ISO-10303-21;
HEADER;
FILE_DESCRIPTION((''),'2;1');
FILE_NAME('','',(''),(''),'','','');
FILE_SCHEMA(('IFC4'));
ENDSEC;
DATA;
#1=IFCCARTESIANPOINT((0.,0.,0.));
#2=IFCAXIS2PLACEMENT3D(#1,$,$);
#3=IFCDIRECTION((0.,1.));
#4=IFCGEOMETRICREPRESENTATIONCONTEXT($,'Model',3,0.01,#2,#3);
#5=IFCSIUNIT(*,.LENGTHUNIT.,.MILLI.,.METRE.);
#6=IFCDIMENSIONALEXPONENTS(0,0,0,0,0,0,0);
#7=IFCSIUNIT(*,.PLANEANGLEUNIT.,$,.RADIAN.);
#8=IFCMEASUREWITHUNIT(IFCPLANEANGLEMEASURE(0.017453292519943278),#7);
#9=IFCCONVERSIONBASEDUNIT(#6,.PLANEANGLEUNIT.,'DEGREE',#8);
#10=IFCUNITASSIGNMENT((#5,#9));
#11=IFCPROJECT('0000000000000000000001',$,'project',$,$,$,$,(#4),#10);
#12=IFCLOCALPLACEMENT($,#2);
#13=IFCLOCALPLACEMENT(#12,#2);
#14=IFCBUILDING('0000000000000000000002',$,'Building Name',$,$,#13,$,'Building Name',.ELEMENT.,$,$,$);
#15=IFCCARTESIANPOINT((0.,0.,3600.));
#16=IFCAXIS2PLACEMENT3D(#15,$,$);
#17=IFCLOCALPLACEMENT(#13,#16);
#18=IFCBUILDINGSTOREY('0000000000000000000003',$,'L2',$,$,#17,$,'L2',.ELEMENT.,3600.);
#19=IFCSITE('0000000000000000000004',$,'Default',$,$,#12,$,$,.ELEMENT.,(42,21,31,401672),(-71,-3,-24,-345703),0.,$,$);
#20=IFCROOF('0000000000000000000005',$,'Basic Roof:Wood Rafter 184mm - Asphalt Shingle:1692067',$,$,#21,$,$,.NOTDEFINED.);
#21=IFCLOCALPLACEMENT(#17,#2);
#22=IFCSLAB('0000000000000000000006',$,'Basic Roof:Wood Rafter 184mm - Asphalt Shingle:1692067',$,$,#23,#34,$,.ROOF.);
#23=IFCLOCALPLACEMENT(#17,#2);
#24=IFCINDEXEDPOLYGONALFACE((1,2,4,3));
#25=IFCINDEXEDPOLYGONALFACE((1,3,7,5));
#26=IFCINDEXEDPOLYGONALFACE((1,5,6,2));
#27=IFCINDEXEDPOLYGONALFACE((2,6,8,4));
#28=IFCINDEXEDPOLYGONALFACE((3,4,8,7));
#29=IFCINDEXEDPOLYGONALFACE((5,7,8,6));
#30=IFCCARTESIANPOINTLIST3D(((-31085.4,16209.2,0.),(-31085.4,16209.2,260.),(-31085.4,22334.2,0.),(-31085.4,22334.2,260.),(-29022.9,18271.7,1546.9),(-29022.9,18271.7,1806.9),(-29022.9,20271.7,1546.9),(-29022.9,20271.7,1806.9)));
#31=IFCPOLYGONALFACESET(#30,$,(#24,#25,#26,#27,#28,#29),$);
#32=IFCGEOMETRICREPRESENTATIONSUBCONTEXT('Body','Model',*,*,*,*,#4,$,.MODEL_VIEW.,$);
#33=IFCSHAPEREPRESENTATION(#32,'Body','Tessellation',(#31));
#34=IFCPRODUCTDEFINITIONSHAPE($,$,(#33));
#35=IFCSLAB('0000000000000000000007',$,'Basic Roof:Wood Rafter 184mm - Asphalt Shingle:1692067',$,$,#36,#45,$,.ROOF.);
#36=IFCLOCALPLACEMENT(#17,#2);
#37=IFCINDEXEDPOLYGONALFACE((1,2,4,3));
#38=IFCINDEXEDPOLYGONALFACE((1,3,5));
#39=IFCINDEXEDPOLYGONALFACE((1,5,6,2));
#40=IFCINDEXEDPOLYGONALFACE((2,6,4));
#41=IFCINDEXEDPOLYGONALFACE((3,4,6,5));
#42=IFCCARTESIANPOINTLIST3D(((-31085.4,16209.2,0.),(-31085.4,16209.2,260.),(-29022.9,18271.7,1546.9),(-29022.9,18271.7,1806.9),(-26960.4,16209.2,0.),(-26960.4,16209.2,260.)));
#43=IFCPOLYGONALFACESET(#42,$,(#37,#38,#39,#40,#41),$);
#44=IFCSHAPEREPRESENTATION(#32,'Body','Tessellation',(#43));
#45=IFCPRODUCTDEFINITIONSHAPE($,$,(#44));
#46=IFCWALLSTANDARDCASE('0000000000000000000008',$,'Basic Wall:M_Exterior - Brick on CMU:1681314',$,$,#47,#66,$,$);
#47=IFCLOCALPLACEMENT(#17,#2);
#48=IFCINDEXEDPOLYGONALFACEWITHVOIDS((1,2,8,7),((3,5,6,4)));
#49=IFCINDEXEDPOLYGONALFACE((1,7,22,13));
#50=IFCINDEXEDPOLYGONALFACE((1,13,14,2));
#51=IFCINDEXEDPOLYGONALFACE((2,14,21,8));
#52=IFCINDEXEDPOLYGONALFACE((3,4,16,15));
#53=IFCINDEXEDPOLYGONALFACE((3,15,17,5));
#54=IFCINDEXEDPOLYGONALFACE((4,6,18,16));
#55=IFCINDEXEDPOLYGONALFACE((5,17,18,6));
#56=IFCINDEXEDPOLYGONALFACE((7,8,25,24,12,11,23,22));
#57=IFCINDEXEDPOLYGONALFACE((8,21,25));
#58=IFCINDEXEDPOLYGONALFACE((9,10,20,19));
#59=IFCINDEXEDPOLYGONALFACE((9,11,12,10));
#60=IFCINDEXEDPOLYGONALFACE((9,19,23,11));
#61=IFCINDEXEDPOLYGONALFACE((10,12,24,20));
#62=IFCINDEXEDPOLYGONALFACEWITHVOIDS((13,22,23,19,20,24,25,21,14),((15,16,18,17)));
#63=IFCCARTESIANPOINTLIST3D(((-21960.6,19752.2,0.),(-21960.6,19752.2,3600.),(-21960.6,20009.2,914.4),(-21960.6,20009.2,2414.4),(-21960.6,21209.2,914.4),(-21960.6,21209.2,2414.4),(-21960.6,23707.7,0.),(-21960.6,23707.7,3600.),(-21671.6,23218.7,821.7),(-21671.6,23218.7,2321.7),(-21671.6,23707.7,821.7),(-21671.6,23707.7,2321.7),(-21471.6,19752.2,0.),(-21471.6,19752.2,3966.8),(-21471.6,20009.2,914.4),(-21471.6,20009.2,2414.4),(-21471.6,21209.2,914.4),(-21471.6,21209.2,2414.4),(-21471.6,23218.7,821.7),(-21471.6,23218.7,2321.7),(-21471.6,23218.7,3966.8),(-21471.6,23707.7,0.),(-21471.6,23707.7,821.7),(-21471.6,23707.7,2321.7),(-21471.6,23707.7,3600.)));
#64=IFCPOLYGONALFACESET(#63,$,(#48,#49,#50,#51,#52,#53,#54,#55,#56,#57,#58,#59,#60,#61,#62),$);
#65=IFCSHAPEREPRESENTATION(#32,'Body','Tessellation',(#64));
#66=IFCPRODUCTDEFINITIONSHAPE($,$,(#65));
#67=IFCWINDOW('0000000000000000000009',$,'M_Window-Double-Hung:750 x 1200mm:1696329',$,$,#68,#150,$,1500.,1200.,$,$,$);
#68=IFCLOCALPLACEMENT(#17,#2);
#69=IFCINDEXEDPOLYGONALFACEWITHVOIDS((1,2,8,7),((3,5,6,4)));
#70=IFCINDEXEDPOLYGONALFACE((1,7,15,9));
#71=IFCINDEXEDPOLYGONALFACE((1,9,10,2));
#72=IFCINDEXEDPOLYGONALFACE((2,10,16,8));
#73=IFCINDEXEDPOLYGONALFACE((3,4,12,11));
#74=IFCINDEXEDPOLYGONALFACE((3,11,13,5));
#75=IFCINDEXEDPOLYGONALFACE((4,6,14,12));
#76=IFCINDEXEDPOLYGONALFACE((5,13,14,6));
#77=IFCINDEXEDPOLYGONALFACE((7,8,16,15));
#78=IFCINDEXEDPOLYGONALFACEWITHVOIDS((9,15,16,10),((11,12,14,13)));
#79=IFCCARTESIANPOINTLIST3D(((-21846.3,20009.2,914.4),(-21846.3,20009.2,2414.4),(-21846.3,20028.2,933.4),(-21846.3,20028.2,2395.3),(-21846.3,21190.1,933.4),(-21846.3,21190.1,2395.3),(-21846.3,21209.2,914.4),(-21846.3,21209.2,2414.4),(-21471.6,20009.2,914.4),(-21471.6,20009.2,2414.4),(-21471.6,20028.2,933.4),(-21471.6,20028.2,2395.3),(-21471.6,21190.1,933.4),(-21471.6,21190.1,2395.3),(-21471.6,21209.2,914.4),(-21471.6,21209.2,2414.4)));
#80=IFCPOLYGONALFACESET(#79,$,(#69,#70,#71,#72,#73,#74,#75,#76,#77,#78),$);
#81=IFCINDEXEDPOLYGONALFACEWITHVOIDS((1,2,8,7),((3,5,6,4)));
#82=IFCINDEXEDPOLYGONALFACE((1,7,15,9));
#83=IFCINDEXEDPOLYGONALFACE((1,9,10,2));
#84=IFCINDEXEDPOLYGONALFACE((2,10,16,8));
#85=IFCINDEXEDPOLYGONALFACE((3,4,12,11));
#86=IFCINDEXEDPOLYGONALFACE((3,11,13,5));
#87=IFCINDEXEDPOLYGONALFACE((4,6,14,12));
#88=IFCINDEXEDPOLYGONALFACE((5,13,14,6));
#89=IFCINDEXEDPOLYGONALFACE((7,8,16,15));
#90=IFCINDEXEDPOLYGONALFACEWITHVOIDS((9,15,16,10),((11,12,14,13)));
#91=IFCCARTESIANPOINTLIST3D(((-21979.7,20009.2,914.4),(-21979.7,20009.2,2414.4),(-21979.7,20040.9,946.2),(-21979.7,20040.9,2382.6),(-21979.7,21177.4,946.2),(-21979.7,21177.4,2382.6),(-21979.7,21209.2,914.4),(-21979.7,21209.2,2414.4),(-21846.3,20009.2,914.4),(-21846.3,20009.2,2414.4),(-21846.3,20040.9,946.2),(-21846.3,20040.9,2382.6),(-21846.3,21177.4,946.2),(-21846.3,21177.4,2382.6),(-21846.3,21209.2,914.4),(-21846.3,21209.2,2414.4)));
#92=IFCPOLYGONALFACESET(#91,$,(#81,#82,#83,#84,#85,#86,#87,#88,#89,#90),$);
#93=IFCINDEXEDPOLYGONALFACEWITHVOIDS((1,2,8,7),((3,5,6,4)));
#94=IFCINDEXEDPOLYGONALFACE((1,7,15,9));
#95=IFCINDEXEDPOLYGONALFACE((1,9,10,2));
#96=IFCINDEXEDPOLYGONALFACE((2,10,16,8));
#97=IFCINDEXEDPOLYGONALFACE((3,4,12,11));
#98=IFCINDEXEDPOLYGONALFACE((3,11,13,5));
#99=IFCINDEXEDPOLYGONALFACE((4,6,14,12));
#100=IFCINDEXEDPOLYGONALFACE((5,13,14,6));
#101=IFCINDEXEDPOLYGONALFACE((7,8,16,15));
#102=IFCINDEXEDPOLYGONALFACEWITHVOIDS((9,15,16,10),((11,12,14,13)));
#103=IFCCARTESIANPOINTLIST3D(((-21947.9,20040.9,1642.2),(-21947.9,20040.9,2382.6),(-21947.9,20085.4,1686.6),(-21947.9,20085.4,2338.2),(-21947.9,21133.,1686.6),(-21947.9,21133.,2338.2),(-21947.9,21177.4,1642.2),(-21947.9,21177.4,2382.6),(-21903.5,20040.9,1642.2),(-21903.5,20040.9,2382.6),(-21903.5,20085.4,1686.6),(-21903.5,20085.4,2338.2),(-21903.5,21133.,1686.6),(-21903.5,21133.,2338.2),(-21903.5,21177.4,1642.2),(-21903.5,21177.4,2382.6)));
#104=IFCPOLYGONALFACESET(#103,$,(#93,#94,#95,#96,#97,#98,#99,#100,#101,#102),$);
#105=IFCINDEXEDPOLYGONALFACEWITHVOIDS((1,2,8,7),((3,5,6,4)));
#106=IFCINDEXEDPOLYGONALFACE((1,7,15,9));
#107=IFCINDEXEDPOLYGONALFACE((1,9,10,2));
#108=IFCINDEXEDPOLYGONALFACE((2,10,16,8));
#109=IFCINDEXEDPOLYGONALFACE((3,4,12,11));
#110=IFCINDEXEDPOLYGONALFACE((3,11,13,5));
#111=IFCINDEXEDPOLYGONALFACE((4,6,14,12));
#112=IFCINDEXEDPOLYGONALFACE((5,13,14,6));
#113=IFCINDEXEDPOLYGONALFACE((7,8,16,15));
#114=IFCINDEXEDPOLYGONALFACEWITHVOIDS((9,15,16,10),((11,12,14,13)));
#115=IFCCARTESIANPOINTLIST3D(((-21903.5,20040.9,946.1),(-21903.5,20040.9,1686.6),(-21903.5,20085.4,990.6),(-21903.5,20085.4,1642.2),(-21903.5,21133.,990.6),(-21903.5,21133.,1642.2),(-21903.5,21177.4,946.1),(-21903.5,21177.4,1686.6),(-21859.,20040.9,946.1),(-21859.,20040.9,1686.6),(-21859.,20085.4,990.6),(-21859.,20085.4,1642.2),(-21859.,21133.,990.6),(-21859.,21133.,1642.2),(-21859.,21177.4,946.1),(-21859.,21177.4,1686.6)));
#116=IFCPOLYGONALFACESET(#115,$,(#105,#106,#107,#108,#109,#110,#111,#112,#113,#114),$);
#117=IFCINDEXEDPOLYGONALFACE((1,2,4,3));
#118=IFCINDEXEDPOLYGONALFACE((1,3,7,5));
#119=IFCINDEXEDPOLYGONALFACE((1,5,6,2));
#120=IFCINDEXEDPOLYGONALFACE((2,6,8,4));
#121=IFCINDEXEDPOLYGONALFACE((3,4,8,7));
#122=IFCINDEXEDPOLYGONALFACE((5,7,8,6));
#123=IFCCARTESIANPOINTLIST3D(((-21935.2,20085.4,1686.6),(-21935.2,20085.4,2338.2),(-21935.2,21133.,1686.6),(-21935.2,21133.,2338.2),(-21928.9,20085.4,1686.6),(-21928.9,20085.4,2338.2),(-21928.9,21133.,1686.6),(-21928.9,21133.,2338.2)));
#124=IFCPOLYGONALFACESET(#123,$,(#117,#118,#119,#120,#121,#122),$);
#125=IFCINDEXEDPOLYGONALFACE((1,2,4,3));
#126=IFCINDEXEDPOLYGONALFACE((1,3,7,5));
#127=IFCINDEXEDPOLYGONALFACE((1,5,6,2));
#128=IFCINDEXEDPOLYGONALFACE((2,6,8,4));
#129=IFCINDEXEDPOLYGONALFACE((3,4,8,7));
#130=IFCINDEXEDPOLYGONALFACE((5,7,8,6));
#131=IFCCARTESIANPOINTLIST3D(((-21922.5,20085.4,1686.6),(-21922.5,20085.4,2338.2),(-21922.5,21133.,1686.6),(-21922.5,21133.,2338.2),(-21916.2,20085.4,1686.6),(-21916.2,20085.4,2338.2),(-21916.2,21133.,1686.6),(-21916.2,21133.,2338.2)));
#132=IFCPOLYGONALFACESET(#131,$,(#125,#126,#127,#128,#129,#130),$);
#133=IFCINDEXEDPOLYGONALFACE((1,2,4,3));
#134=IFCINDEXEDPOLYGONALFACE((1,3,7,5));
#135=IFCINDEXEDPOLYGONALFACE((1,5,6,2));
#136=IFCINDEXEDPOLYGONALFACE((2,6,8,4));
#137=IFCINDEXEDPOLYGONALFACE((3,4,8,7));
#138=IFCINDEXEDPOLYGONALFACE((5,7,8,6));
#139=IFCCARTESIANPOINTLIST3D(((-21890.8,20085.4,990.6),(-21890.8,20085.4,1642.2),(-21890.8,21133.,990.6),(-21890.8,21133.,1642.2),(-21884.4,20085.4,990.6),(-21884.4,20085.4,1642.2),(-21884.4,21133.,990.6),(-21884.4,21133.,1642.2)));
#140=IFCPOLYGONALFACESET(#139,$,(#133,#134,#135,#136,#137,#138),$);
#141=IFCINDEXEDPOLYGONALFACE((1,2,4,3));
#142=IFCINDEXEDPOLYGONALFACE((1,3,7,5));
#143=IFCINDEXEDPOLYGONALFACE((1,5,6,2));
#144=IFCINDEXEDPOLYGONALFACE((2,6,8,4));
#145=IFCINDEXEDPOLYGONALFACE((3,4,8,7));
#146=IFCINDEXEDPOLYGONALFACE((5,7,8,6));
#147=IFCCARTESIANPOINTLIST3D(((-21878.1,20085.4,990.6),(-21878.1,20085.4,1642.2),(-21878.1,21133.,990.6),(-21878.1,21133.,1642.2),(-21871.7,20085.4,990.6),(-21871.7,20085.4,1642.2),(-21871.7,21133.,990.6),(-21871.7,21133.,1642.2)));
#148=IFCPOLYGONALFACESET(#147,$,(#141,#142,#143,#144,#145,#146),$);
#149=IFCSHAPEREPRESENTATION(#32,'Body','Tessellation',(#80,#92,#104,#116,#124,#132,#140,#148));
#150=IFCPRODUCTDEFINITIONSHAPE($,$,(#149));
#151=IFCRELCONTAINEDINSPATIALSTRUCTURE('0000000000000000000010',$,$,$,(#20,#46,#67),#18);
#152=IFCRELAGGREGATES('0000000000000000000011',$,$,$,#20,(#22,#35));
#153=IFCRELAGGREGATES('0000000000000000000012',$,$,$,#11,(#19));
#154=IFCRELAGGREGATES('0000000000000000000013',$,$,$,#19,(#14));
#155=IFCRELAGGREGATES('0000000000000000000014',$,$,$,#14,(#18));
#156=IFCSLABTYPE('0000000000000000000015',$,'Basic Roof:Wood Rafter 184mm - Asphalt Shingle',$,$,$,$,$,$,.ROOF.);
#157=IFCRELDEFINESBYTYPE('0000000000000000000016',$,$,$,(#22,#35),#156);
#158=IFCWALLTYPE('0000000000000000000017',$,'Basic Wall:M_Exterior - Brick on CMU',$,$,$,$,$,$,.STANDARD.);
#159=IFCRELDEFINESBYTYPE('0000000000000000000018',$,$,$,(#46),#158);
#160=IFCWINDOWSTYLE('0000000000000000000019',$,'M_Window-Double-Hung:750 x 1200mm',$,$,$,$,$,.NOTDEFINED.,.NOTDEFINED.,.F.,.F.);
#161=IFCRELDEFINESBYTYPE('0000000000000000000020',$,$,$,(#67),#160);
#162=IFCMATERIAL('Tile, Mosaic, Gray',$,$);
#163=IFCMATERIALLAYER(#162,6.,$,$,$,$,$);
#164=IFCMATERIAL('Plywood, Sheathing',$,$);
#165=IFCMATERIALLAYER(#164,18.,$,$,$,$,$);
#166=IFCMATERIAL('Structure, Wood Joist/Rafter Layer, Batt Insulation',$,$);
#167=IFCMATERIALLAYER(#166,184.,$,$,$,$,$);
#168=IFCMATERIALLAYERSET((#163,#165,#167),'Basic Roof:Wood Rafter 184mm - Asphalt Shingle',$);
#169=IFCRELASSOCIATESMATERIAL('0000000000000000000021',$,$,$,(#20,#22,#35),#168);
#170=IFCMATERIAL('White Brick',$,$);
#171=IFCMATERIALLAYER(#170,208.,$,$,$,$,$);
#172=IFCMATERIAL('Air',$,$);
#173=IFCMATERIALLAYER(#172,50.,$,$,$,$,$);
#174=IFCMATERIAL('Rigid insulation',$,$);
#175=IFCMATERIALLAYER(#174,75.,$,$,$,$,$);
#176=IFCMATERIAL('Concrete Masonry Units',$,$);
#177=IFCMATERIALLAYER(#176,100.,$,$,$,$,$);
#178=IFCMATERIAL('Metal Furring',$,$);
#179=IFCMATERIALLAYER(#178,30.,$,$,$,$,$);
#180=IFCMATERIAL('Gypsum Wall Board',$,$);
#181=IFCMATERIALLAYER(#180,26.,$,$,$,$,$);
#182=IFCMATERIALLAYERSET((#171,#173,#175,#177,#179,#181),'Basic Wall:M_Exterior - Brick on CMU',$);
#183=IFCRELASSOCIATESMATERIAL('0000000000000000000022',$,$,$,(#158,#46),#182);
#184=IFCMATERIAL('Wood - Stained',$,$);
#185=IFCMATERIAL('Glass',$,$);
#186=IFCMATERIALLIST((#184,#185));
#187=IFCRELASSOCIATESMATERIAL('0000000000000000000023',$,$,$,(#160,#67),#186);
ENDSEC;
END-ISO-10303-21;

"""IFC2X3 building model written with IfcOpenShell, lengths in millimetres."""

from ifc_helpers import new_model, entity, si_unit, converted_unit, direction, frame, frame_2d, origin, place, context, subcontext, project, spatial, polyline, rectangle, outline, extrude, clip, bounded_halfspace, source, transform, mapped, material, material_list, layer, layer_set, layer_usage, type_object, type_shapes, element, fill, aggregate, save


model = new_model("IFC2X3")

# Units and contexts
model_context = context("Model", 3, precision=0.01, world=origin(), true_north=direction((0.0, 1.0)))
body_context = subcontext(model_context, "Body", "Model", "MODEL_VIEW")
ifc_project = project(units=[si_unit("LENGTHUNIT", "METRE", prefix="MILLI"), converted_unit("PLANEANGLEUNIT", "DEGREE", entity("IfcPlaneAngleMeasure", 0.017453292519943278), si_unit("PLANEANGLEUNIT", "RADIAN"), dimensions=[0, 0, 0, 0, 0, 0, 0])], contexts=[model_context])

# Site, building, storey
site_placement = place(None, origin())
site = spatial("IfcSite", under=ifc_project, at=site_placement, Name="Default", CompositionType="ELEMENT", RefLatitude=(42, 21, 31, 401672), RefLongitude=(-71, -3, -24, -345703), RefElevation=0.0)
building_placement = place(site_placement, origin())
building = spatial("IfcBuilding", under=site, at=building_placement, Name="Building Name", LongName="Building Name", CompositionType="ELEMENT")
storey_placement = place(building_placement, frame((0.0, 0.0, 3600.0)))
storey = spatial("IfcBuildingStorey", under=building, at=storey_placement, Name="L2", LongName="L2", CompositionType="ELEMENT", Elevation=3600.0)

# Roof, slabs
ifc_material_1 = material(Name="Tile, Mosaic, Gray")
ifc_layer_1 = layer(ifc_material_1, 6.0)
ifc_material_2 = material(Name="Plywood, Sheathing")
ifc_layer_2 = layer(ifc_material_2, 18.0)
ifc_material_3 = material(Name="Structure, Wood Joist/Rafter Layer, Batt Insulation")
ifc_layer_3 = layer(ifc_material_3, 184.0)
ifc_layer_set_1 = layer_set([ifc_layer_1, ifc_layer_2, ifc_layer_3], Name="Basic Roof:Wood Rafter 184mm - Asphalt Shingle")
slab_type = type_object("IfcSlabType", Name="Basic Roof:Wood Rafter 184mm - Asphalt Shingle", PredefinedType="ROOF")
roof_1_placement = place(storey_placement, frame((-31085.4, 16209.2, 0.0)))
roof_1 = element("IfcRoof", 1, at=roof_1_placement, inside=storey, material=ifc_layer_set_1, Name="Basic Roof:Wood Rafter 184mm - Asphalt Shingle:1692067", ShapeType="NOTDEFINED")
slab_1_placement = place(roof_1_placement, origin())
slab_1 = element("IfcSlab", 2, at=slab_1_placement, type_object=slab_type, material=ifc_layer_set_1, Name="Basic Roof:Wood Rafter 184mm - Asphalt Shingle:1692067", PredefinedType="ROOF", context=body_context, shape_type="SweptSolid", body=[
    extrude(outline(polyline([(-1289.1, 3062.5), (-1289.1, -3062.5), (1289.1, -1000.0), (1289.1, 1000.0), (-1289.1, 3062.5)])), frame((1031.2, 3062.5, 773.4), z_axis=(-0.6, 0.0, 0.8), x_axis=(0.8, 0.0, 0.6)), (0.6, 0.0, 0.8), 260.0),
])
slab_2_placement = place(roof_1_placement, origin())
slab_2 = element("IfcSlab", 3, at=slab_2_placement, type_object=slab_type, material=ifc_layer_set_1, Name="Basic Roof:Wood Rafter 184mm - Asphalt Shingle:1692067", PredefinedType="ROOF", context=body_context, shape_type="SweptSolid", body=[
    extrude(outline(polyline([(-2062.5, -1289.1), (2062.5, -1289.1), (0.0, 1289.1), (-2062.5, -1289.1)])), frame((2062.5, 1031.2, 773.4), z_axis=(0.0, -0.6, 0.8), x_axis=(1.0, 0.0, 0.0)), (0.0, 0.6, 0.8), 260.0),
])
aggregate(roof_1, [slab_1, slab_2])

# Wall, openings, window
ifc_material_4 = material(Name="White Brick")
ifc_layer_4 = layer(ifc_material_4, 208.0)
ifc_material_5 = material(Name="Air")
ifc_layer_5 = layer(ifc_material_5, 50.0)
ifc_material_6 = material(Name="Rigid insulation")
ifc_layer_6 = layer(ifc_material_6, 75.0)
ifc_material_7 = material(Name="Concrete Masonry Units")
ifc_layer_7 = layer(ifc_material_7, 100.0)
ifc_material_8 = material(Name="Metal Furring")
ifc_layer_8 = layer(ifc_material_8, 30.0)
ifc_material_9 = material(Name="Gypsum Wall Board")
ifc_layer_9 = layer(ifc_material_9, 26.0)
ifc_layer_set_2 = layer_set([ifc_layer_4, ifc_layer_5, ifc_layer_6, ifc_layer_7, ifc_layer_8, ifc_layer_9], Name="Basic Wall:M_Exterior - Brick on CMU")
ifc_layer_usage_1 = layer_usage(ifc_layer_set_2, "AXIS2", "NEGATIVE", 244.5)
wall_type = type_object("IfcWallType", Name="Basic Wall:M_Exterior - Brick on CMU", PredefinedType="STANDARD", material=ifc_layer_set_2)
wall_1_placement = place(storey_placement, frame((-21716.1, 19752.2, 0.0), z_axis=(0.0, 0.0, 1.0), x_axis=(0.0, 1.0, 0.0)))
wall_1 = element("IfcWallStandardCase", 4, at=wall_1_placement, inside=storey, type_object=wall_type, material=ifc_layer_usage_1, Name="Basic Wall:M_Exterior - Brick on CMU:1681314", context=body_context, shape_type="Clipping", body=[
    clip(clip(extrude(rectangle(XDim=3955.5, YDim=489.0, at=frame_2d((1977.8, 0.0), x_axis=(-1.0, 0.0))), origin(), (0.0, 0.0, 1.0), 3966.8), bounded_halfspace(frame((3955.5, 244.5, 3600.0), z_axis=(0.0, 0.6, 0.8), x_axis=(-1.0, 0.0, 0.0)), False, frame((3955.5, 244.5, 3600.0)), polyline([(0.0, 0.0), (-3955.5, 0.0), (-3955.5, -489.0), (-489.0, -489.0), (0.0, 0.0)]))), bounded_halfspace(frame((3955.5, -244.5, 3600.0), z_axis=(0.6, 0.0, 0.8), x_axis=(0.0, 1.0, 0.0)), False, frame((3955.5, -244.5, 3600.0)), polyline([(0.0, 0.0), (0.0, 489.0), (-489.0, 0.0), (0.0, 0.0)]))),
])
opening_1_placement = place(wall_1_placement, origin())
element("IfcOpeningElement", 5, at=opening_1_placement, cuts=wall_1, ObjectType="Opening", context=body_context, shape_type="SweptSolid", body=[
    extrude(rectangle(XDim=1500.0, YDim=489.0, at=frame_2d((0.0, 0.0), x_axis=(0.0, 1.0))), frame((3711.0, -1244.5, 1571.7), z_axis=(0.0, 1.0, 0.0), x_axis=(1.0, 0.0, 0.0)), (0.0, 0.0, 1.0), 1200.0),
])
opening_2_placement = place(wall_1_placement, frame((257.0, -244.5, 914.4)))
opening_2 = element("IfcOpeningElement", 6, at=opening_2_placement, cuts=wall_1, ObjectType="Opening", context=body_context, shape_type="SweptSolid", body=[
    extrude(rectangle(XDim=1500.0, YDim=1200.0, at=frame_2d((750.0, 600.0), x_axis=(-1.0, 0.0))), frame((0.0, 0.0, 0.0), z_axis=(0.0, 1.0, 0.0), x_axis=(0.0, 0.0, 1.0)), (0.0, 0.0, 1.0), 489.0),
])
ifc_material_10 = material(Name="Wood - Stained")
ifc_material_11 = material(Name="Glass")
ifc_material_list_1 = material_list([ifc_material_10, ifc_material_11])
window_style = type_object("IfcWindowStyle", Name="M_Window-Double-Hung:750 x 1200mm", ConstructionType="NOTDEFINED", OperationType="NOTDEFINED", ParameterTakesPrecedence=False, Sizeable=False, material=ifc_material_list_1)
shared_shape_1 = source(origin(), body_context, "Body", "SweptSolid", [
    extrude(outline(polyline([(-750.0, -600.0), (750.0, -600.0), (750.0, 600.0), (-750.0, 600.0), (-750.0, -600.0)]), holes=[polyline([(-730.9, -580.9), (-730.9, 580.9), (730.9, 580.9), (730.9, -580.9), (-730.9, -580.9)])]), frame((600.0, 0.0, 750.0), z_axis=(0.0, 1.0, 0.0), x_axis=(0.0, 0.0, -1.0)), (0.0, 0.0, 1.0), 374.7),
    extrude(outline(polyline([(-600.0, -750.0), (600.0, -750.0), (600.0, 750.0), (-600.0, 750.0), (-600.0, -750.0)]), holes=[polyline([(568.2, -718.2), (-568.2, -718.2), (-568.2, 718.2), (568.2, 718.2), (568.2, -718.2)])]), frame((600.0, 374.7, 750.0), z_axis=(0.0, 1.0, 0.0), x_axis=(1.0, 0.0, 0.0)), (0.0, 0.0, 1.0), 133.3),
    extrude(outline(polyline([(-568.2, -370.2), (568.2, -370.2), (568.2, 370.2), (-568.2, 370.2), (-568.2, -370.2)]), holes=[polyline([(523.8, -325.8), (-523.8, -325.8), (-523.8, 325.8), (523.8, 325.8), (523.8, -325.8)])]), frame((600.0, 431.8, 1098.0), z_axis=(0.0, 1.0, 0.0), x_axis=(1.0, 0.0, 0.0)), (0.0, 0.0, 1.0), 44.4),
    extrude(outline(polyline([(-568.2, -370.2), (568.2, -370.2), (568.2, 370.2), (-568.2, 370.2), (-568.2, -370.2)]), holes=[polyline([(523.8, -325.8), (-523.8, -325.8), (-523.8, 325.8), (523.8, 325.8), (523.8, -325.8)])]), frame((600.0, 387.4, 402.0), z_axis=(0.0, 1.0, 0.0), x_axis=(1.0, 0.0, 0.0)), (0.0, 0.0, 1.0), 44.5),
    extrude(rectangle(XDim=1047.6, YDim=6.4, at=frame_2d((0.0, 0.0), x_axis=(1.0, 0.0))), frame((600.0, 460.4, 772.2), z_axis=(0.0, 0.0, 1.0), x_axis=(-1.0, 0.0, 0.0)), (0.0, 0.0, 1.0), 651.6),
    extrude(rectangle(XDim=6.4, YDim=1047.6, at=frame_2d((0.0, 0.0), x_axis=(1.0, 0.0))), frame((600.0, 447.7, 772.2), z_axis=(0.0, 0.0, 1.0), x_axis=(0.0, -1.0, 0.0)), (0.0, 0.0, 1.0), 651.6),
    extrude(rectangle(XDim=1047.6, YDim=6.4, at=frame_2d((0.0, 0.0), x_axis=(1.0, 0.0))), frame((600.0, 416.0, 76.2), z_axis=(0.0, 0.0, 1.0), x_axis=(-1.0, 0.0, 0.0)), (0.0, 0.0, 1.0), 651.6),
    extrude(rectangle(XDim=6.4, YDim=1047.6, at=frame_2d((0.0, 0.0), x_axis=(1.0, 0.0))), frame((600.0, 403.3, 76.2), z_axis=(0.0, 0.0, 1.0), x_axis=(0.0, -1.0, 0.0)), (0.0, 0.0, 1.0), 651.6),
])
type_shapes(window_style, [shared_shape_1])
window_1_placement = place(opening_2_placement, origin())
window_1 = element("IfcWindow", 7, at=window_1_placement, inside=storey, type_object=window_style, material=ifc_material_list_1, Name="M_Window-Double-Hung:750 x 1200mm:1696329", OverallHeight=1500.0, OverallWidth=1200.0, context=body_context, shape_type="MappedRepresentation", body=[
    mapped(shared_shape_1, transform((0.0, 0.0, 0.0), scale=1.0)),
])
fill(opening_2, window_1)

save(model, "model.ifc")
